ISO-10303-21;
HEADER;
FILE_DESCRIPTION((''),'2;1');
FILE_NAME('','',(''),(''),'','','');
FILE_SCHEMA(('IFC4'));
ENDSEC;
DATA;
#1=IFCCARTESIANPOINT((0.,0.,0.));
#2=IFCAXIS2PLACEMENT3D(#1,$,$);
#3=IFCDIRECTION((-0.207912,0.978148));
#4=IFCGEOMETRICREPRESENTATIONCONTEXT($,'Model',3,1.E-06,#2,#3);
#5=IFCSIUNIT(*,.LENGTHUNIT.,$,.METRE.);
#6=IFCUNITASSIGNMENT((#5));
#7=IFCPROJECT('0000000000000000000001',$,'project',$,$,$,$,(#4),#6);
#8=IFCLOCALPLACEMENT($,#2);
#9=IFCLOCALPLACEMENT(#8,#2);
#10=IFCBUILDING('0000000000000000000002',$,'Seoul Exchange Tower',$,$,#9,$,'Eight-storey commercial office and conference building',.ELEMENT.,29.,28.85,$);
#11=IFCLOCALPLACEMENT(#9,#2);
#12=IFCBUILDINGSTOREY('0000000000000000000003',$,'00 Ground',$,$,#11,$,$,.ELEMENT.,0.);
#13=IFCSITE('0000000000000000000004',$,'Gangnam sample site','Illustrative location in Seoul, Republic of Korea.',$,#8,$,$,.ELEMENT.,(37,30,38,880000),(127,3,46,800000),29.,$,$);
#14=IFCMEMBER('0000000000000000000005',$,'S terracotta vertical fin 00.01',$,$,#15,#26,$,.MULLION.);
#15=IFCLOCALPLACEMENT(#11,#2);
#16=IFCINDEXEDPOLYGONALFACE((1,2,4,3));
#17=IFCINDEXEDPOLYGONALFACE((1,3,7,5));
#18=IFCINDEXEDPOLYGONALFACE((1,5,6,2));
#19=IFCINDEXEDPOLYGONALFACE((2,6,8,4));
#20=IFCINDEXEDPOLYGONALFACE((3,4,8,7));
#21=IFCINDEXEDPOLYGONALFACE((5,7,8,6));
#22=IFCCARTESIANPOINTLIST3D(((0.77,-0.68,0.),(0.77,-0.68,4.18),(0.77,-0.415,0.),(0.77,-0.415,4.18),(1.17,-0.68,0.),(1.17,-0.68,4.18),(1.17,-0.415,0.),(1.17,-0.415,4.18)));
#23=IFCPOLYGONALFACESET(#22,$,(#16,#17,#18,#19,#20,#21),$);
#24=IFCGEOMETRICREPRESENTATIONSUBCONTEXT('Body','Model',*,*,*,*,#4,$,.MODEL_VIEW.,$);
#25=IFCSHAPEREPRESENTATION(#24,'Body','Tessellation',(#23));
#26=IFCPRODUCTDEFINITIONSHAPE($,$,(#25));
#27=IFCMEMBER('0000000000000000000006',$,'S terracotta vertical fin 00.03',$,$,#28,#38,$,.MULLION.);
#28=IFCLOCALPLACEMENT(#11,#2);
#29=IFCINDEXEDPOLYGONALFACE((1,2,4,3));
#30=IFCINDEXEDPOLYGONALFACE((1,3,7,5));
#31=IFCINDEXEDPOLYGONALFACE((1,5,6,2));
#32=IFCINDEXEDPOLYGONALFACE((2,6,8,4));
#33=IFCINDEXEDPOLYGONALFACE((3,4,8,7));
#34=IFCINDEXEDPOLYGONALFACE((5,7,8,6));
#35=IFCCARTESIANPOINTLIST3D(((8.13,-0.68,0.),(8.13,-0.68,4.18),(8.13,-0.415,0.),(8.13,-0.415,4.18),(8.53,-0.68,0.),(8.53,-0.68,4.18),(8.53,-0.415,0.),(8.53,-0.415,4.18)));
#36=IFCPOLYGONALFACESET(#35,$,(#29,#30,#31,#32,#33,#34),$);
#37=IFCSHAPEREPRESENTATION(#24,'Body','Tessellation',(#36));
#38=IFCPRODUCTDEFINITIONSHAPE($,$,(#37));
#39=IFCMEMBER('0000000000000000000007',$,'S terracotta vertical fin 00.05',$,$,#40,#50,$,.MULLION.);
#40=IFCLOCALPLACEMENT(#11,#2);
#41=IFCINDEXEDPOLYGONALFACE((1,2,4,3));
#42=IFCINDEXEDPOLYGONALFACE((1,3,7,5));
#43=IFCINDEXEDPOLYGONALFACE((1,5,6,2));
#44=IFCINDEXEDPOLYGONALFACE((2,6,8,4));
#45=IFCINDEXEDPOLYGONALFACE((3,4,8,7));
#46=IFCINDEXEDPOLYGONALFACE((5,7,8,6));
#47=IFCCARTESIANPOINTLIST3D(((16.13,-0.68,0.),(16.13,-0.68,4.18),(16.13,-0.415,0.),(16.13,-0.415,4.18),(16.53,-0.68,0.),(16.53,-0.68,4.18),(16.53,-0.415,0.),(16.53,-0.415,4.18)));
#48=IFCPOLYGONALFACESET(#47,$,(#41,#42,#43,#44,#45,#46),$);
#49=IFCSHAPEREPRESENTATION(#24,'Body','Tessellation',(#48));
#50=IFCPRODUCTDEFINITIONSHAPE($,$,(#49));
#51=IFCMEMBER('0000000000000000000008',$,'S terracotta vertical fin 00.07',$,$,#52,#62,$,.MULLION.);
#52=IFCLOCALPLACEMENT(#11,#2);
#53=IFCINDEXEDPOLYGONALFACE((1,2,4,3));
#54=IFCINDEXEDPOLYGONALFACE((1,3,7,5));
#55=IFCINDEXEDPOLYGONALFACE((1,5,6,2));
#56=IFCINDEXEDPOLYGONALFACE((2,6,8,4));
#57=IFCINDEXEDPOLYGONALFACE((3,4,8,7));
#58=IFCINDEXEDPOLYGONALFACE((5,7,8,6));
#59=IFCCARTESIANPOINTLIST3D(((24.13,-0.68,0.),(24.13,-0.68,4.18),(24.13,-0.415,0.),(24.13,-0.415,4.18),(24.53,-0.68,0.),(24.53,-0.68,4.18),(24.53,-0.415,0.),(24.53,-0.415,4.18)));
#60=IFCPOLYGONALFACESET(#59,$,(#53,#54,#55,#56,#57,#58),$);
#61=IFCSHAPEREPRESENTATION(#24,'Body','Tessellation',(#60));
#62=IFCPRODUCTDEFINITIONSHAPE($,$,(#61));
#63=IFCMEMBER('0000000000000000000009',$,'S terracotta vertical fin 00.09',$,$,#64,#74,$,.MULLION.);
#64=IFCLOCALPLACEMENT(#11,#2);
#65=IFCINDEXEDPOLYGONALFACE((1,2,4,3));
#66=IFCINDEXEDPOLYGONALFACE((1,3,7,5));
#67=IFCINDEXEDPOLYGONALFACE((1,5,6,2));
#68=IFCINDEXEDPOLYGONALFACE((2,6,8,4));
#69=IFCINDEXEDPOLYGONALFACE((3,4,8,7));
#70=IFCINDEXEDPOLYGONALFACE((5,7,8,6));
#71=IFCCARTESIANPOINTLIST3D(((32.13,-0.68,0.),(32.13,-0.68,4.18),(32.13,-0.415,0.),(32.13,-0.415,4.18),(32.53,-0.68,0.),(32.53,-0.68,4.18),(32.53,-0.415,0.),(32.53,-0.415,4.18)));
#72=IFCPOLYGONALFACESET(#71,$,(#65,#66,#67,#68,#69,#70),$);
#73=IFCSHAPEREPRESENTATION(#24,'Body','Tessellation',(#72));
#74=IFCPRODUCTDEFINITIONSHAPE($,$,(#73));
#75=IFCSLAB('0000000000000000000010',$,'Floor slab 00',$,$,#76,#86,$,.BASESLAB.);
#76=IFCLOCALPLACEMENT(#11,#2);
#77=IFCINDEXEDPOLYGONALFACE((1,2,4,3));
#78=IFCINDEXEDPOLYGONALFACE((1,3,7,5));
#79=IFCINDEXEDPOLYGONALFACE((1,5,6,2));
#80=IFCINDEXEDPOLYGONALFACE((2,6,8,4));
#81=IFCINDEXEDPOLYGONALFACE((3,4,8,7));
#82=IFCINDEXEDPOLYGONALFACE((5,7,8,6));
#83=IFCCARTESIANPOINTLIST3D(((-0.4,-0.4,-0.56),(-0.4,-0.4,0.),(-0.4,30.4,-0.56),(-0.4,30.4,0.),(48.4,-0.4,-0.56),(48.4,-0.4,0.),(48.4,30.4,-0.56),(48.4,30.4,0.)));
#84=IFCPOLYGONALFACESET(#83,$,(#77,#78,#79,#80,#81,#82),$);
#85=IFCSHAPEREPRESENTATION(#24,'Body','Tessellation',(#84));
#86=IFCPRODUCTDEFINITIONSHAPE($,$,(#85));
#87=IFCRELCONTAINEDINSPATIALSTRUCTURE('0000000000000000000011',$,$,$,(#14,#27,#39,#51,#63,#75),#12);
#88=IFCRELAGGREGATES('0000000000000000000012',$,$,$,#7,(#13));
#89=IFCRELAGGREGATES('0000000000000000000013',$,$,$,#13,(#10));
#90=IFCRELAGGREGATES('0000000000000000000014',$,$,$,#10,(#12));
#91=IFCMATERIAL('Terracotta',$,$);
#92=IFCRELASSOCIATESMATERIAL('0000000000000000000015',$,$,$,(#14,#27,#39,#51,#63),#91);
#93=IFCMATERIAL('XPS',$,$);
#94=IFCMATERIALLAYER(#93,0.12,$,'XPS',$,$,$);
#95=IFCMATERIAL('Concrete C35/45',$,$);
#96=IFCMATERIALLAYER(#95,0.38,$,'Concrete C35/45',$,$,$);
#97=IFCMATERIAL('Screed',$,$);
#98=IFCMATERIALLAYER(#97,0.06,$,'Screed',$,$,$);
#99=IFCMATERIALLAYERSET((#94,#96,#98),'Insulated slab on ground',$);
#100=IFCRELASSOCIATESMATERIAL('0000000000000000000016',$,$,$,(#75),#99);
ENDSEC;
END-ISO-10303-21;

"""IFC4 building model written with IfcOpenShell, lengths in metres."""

from ifc_helpers import new_model, si_unit, direction, frame, frame_2d, origin, place, context, subcontext, project, spatial, rectangle, extrude, material, layer, layer_set, layer_usage, element, save


model = new_model("IFC4")

# Units and contexts
model_context = context("Model", 3, precision=1e-06, world=origin(), true_north=direction((-0.207912, 0.978148)))
body_context = subcontext(model_context, "Body", "Model", "MODEL_VIEW")
ifc_project = project(units=[si_unit("LENGTHUNIT", "METRE")], contexts=[model_context])

# Site, building, storey
site_placement = place(None, origin())
site = spatial("IfcSite", under=ifc_project, at=site_placement, Name="Gangnam sample site", Description="Illustrative location in Seoul, Republic of Korea.", CompositionType="ELEMENT", RefLatitude=(37, 30, 38, 880000), RefLongitude=(127, 3, 46, 800000), RefElevation=29.0)
building_placement = place(site_placement, origin())
building = spatial("IfcBuilding", under=site, at=building_placement, Name="Seoul Exchange Tower", LongName="Eight-storey commercial office and conference building", CompositionType="ELEMENT", ElevationOfRefHeight=29.0, ElevationOfTerrain=28.85)
storey_placement = place(building_placement, origin())
storey = spatial("IfcBuildingStorey", under=building, at=storey_placement, Name="00 Ground", CompositionType="ELEMENT", Elevation=0.0)

# Members
ifc_material_1 = material(Name="Terracotta")
wall_placement = place(storey_placement, frame((-0.4, -0.4, 0.0), z_axis=(0.0, 0.0, 1.0), x_axis=(1.0, 0.0, 0.0)))
placement = place(wall_placement, origin())
element("IfcMember", 1, at=placement, inside=storey, material=ifc_material_1, Name="S terracotta vertical fin 00.01", PredefinedType="MULLION", context=body_context, shape_type="SweptSolid", body=[
    extrude(rectangle(XDim=0.4, YDim=0.265, at=frame_2d((0.2, 0.1325))), frame((1.17, -0.28, 0.0)), (0.0, 0.0, 1.0), 4.18),
])
element("IfcMember", 2, at=placement, inside=storey, material=ifc_material_1, Name="S terracotta vertical fin 00.03", PredefinedType="MULLION", context=body_context, shape_type="SweptSolid", body=[
    extrude(rectangle(XDim=0.4, YDim=0.265, at=frame_2d((0.2, 0.1325))), frame((8.53, -0.28, 0.0)), (0.0, 0.0, 1.0), 4.18),
])
element("IfcMember", 3, at=placement, inside=storey, material=ifc_material_1, Name="S terracotta vertical fin 00.05", PredefinedType="MULLION", context=body_context, shape_type="SweptSolid", body=[
    extrude(rectangle(XDim=0.4, YDim=0.265, at=frame_2d((0.2, 0.1325))), frame((16.53, -0.28, 0.0)), (0.0, 0.0, 1.0), 4.18),
])
element("IfcMember", 4, at=placement, inside=storey, material=ifc_material_1, Name="S terracotta vertical fin 00.07", PredefinedType="MULLION", context=body_context, shape_type="SweptSolid", body=[
    extrude(rectangle(XDim=0.4, YDim=0.265, at=frame_2d((0.2, 0.1325))), frame((24.53, -0.28, 0.0)), (0.0, 0.0, 1.0), 4.18),
])
element("IfcMember", 5, at=placement, inside=storey, material=ifc_material_1, Name="S terracotta vertical fin 00.09", PredefinedType="MULLION", context=body_context, shape_type="SweptSolid", body=[
    extrude(rectangle(XDim=0.4, YDim=0.265, at=frame_2d((0.2, 0.1325))), frame((32.53, -0.28, 0.0)), (0.0, 0.0, 1.0), 4.18),
])

# Slab
ifc_material_2 = material(Name="XPS")
ifc_layer_1 = layer(ifc_material_2, 0.12, Name="XPS")
ifc_material_3 = material(Name="Concrete C35/45")
ifc_layer_2 = layer(ifc_material_3, 0.38, Name="Concrete C35/45")
ifc_material_4 = material(Name="Screed")
ifc_layer_3 = layer(ifc_material_4, 0.06, Name="Screed")
ifc_layer_set_1 = layer_set([ifc_layer_1, ifc_layer_2, ifc_layer_3], Name="Insulated slab on ground")
ifc_layer_usage_1 = layer_usage(ifc_layer_set_1, "AXIS3", "POSITIVE", 0.0)
slab_placement = place(storey_placement, frame((0.0, 0.0, -0.56)))
element("IfcSlab", 6, at=slab_placement, inside=storey, material=ifc_layer_usage_1, Name="Floor slab 00", PredefinedType="BASESLAB", context=body_context, shape_type="SweptSolid", body=[
    extrude(rectangle(XDim=48.8, YDim=30.8, at=frame_2d((24.4, 15.4))), frame((-0.4, -0.4, 0.0)), (0.0, 0.0, 1.0), 0.56),
])

save(model, "model.ifc")
